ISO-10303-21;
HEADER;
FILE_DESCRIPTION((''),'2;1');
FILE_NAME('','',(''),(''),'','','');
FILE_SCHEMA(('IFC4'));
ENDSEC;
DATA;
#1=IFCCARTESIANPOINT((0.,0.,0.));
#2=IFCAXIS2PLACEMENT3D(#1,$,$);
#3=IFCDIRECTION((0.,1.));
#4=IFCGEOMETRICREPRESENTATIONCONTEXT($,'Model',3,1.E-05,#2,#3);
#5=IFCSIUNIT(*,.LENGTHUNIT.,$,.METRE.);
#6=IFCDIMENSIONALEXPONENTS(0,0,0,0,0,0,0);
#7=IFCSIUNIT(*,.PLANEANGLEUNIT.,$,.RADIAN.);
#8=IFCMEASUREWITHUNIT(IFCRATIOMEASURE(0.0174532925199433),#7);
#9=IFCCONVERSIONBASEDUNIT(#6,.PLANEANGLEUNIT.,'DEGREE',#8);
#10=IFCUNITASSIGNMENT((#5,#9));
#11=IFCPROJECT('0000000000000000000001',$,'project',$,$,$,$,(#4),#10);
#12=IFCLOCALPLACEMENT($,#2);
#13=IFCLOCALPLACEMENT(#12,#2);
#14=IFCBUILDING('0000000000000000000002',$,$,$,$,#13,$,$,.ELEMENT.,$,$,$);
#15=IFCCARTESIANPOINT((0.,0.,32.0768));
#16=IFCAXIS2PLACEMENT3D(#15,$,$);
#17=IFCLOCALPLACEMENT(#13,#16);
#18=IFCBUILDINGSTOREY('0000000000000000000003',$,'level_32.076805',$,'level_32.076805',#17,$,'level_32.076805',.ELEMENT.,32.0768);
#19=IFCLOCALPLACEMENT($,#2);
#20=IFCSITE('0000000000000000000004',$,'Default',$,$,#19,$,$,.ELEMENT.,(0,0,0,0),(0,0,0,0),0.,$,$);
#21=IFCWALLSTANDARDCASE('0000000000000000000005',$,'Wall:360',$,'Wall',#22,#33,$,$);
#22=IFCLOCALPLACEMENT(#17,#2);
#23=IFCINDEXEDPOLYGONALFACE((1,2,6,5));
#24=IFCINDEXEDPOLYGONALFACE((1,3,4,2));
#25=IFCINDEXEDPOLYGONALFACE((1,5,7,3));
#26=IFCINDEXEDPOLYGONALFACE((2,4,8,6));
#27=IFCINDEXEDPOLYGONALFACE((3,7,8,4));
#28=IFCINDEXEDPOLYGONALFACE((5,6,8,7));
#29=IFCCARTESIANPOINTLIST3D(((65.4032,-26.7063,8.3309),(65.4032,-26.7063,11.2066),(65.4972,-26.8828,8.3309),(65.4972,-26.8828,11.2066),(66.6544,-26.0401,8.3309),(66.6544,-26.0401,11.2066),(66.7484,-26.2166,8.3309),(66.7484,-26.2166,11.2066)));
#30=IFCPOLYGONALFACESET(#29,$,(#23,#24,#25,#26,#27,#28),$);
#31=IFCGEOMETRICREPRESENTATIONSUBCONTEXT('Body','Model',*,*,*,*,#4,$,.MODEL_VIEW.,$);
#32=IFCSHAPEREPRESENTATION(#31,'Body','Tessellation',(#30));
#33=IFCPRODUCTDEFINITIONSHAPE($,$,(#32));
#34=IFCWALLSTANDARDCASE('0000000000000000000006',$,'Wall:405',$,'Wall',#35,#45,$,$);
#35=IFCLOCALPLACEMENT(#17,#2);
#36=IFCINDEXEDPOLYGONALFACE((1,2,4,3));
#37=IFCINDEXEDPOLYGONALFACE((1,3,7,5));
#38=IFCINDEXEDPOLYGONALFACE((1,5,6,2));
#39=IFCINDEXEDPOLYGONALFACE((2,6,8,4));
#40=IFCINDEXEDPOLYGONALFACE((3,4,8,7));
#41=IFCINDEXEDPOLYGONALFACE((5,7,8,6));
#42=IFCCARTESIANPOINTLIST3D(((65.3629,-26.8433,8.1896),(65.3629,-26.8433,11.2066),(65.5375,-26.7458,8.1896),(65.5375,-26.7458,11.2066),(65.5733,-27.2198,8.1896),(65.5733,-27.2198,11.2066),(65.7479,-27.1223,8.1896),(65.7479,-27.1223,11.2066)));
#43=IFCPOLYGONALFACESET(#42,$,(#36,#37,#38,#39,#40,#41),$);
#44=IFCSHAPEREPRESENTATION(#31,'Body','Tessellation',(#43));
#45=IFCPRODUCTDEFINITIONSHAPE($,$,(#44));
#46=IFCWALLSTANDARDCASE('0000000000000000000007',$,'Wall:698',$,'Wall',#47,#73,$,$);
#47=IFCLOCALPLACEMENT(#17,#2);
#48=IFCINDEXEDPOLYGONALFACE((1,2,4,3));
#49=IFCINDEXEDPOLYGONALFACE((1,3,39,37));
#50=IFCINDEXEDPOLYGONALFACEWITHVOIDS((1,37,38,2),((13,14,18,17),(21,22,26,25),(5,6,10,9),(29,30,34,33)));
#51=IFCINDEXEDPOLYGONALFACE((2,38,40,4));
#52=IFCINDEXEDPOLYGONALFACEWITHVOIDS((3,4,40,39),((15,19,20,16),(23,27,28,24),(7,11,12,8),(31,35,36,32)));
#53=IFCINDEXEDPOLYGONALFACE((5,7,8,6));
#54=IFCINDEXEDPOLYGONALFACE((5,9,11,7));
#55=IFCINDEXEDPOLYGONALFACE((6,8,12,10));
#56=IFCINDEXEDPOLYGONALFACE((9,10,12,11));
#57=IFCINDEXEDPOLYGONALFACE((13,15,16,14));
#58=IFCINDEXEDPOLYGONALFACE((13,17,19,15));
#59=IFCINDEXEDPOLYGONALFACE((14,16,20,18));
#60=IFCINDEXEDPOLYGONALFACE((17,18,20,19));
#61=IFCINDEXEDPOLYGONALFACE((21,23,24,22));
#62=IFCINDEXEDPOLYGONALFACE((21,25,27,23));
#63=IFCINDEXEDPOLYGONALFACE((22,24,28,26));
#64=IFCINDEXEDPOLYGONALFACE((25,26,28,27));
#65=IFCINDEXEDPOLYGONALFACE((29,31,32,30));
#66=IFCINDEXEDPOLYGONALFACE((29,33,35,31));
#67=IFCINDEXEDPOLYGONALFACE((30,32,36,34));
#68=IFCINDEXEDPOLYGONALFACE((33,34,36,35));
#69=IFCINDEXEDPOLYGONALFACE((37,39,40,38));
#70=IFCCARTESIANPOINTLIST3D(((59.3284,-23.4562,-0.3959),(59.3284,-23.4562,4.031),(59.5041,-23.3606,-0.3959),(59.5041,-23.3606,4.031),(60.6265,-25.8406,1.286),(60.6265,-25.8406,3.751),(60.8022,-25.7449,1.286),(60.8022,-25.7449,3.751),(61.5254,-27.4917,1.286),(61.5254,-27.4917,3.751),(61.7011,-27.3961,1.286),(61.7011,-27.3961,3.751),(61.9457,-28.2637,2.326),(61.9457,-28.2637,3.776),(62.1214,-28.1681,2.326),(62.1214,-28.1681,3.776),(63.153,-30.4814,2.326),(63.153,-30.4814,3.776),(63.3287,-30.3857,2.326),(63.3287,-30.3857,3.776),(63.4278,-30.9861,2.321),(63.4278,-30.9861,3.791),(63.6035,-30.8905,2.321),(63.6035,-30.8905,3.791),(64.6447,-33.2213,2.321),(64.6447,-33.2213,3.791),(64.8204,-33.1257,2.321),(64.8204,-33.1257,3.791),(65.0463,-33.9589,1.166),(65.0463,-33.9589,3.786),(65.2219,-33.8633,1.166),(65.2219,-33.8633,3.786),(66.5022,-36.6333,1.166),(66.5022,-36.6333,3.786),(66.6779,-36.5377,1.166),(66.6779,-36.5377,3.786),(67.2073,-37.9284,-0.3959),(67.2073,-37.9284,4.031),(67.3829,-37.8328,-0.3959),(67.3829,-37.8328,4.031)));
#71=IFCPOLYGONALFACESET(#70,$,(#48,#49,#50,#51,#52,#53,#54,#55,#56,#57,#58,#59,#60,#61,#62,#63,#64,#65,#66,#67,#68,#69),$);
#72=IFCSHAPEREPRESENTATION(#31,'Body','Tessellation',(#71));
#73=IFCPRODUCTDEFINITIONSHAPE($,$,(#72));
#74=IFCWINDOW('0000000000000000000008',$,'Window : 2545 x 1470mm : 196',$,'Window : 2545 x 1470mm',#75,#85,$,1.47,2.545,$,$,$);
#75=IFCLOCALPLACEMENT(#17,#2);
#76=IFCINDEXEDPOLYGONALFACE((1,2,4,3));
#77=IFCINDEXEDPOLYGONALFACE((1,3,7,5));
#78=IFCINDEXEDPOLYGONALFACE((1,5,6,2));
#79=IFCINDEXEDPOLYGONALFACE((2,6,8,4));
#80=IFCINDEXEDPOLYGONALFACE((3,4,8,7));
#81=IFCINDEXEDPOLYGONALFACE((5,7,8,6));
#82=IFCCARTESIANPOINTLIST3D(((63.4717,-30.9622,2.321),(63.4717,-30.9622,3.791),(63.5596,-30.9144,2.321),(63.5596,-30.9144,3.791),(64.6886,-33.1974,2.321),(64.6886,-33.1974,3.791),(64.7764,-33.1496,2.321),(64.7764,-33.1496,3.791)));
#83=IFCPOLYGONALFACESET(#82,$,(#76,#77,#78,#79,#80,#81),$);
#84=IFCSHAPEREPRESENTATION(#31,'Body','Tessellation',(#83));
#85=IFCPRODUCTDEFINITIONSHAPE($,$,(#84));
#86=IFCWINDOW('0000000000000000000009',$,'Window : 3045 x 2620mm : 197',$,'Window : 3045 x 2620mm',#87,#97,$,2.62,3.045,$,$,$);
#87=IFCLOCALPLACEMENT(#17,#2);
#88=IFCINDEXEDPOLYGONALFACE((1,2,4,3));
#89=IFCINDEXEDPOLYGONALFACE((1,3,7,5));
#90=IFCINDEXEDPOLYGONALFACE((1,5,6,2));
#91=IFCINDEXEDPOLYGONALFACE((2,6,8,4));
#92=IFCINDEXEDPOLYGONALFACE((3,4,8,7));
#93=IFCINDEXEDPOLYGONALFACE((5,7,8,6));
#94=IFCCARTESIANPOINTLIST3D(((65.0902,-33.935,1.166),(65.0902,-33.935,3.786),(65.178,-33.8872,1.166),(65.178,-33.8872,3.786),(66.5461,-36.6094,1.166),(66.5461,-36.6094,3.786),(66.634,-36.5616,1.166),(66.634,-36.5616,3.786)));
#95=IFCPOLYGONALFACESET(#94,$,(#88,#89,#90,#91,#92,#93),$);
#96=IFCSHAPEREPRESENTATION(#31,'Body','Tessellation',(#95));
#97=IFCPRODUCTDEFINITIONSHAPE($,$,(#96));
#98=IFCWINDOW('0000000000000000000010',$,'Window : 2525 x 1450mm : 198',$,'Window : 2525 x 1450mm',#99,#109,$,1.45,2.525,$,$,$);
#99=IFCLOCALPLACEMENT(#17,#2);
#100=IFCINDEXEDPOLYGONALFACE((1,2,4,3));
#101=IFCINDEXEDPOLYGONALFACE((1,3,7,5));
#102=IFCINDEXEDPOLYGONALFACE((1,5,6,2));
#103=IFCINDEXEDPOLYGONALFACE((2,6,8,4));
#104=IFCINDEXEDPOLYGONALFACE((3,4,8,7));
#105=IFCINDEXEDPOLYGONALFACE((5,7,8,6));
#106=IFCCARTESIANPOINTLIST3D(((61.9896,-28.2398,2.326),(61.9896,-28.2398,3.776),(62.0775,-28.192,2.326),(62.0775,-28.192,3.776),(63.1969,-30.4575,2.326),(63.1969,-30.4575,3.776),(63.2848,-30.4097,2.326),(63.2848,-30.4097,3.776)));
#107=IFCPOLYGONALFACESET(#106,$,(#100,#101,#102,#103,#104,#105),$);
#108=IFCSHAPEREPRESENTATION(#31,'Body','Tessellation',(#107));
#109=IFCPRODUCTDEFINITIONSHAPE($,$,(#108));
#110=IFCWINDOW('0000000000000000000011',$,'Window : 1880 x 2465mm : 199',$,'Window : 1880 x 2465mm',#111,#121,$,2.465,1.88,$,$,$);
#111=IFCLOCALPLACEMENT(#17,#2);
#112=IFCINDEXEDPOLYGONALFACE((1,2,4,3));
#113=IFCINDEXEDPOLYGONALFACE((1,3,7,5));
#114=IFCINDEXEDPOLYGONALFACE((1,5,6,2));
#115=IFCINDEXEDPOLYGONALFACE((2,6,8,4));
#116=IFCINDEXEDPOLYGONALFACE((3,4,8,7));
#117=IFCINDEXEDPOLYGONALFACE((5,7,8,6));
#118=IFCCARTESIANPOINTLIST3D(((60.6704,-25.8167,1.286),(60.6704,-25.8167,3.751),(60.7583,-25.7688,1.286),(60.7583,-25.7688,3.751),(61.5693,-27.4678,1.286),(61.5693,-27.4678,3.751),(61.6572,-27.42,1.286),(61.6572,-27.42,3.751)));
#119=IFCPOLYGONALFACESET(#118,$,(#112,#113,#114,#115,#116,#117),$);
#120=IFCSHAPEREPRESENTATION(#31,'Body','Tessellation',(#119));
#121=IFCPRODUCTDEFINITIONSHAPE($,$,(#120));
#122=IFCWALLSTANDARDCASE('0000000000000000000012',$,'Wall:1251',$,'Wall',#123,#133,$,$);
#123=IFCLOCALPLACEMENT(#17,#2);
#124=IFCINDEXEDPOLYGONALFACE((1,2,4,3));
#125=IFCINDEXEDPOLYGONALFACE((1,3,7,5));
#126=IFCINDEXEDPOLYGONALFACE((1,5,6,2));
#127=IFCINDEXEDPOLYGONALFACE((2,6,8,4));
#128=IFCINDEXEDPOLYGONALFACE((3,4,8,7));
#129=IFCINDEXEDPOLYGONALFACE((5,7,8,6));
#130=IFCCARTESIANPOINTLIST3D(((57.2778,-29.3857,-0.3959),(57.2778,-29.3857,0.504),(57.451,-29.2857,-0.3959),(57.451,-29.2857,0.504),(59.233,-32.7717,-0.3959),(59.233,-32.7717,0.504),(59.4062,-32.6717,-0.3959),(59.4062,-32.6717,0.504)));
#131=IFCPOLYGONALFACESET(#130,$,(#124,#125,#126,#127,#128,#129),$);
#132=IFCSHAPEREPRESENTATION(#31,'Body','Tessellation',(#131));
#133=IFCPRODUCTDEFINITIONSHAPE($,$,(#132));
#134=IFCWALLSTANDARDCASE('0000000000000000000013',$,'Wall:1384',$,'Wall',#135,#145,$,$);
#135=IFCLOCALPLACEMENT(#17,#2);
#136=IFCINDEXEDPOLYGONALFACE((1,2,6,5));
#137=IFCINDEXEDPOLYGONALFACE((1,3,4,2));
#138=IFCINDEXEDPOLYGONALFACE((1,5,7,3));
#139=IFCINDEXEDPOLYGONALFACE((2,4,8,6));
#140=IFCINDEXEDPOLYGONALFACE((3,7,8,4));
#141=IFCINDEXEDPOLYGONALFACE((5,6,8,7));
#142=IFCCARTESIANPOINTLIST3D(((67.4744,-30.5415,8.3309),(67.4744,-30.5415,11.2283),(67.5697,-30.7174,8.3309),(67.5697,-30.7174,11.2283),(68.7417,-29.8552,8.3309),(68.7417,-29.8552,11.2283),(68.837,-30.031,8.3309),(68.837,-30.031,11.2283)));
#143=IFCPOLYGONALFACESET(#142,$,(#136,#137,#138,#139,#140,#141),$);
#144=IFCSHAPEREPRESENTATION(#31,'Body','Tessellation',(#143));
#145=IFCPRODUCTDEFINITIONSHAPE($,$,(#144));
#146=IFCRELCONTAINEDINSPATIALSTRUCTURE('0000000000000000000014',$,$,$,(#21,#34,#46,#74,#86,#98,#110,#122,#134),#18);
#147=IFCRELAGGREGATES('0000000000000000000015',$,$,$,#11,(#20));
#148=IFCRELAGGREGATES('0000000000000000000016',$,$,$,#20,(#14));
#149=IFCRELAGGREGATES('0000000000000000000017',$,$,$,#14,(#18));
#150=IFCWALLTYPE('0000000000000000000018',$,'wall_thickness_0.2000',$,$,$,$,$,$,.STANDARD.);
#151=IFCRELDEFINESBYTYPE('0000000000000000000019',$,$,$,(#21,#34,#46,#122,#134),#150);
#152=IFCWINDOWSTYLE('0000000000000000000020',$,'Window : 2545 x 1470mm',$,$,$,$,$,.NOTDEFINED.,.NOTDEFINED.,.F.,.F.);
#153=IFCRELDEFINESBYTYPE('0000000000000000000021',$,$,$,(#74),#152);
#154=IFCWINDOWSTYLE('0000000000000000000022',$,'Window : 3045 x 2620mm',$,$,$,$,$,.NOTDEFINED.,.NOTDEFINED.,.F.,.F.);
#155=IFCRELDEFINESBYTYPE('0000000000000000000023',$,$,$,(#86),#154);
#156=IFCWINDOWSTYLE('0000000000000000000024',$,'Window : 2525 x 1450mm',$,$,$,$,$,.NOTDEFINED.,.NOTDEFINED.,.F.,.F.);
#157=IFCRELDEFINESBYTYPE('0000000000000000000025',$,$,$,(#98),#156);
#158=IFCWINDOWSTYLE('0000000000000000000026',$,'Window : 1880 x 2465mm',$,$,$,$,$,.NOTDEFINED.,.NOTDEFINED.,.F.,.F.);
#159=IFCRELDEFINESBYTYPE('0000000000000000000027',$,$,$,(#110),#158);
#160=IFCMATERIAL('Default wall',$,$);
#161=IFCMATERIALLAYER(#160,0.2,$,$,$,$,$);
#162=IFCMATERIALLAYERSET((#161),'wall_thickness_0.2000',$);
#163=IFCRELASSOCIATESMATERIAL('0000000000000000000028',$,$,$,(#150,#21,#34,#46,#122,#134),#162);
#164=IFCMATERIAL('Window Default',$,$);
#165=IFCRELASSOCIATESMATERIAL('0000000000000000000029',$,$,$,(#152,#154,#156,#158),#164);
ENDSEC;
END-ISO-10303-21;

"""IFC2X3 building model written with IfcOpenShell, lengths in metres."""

from ifc_helpers import new_model, entity, si_unit, converted_unit, direction, frame, frame_2d, origin, origin_2d_with_axis, place, context, subcontext, project, spatial, polyline, rectangle, outline, extrude, source, transform, mapped, material, layer, layer_set, layer_usage, type_object, type_shapes, element, fill, save


model = new_model("IFC2X3")

# Units and contexts
model_context = context("Model", 3, precision=1e-05, world=origin(), true_north=direction((0.0, 1.0)))
body_context = subcontext(model_context, "Body", "Model", "MODEL_VIEW")
ifc_project = project(units=[si_unit("LENGTHUNIT", "METRE"), converted_unit("PLANEANGLEUNIT", "DEGREE", entity("IfcRatioMeasure", 0.0174532925199433), si_unit("PLANEANGLEUNIT", "RADIAN"), dimensions=[0, 0, 0, 0, 0, 0, 0])], contexts=[model_context])

# Site, building, storey
site_placement = place(None, origin())
site = spatial("IfcSite", under=ifc_project, at=site_placement, Name="Default", CompositionType="ELEMENT", RefLatitude=(0, 0, 0, 0), RefLongitude=(0, 0, 0, 0), RefElevation=0.0)
placement_1 = place(None, origin())
building_placement = place(placement_1, origin())
building = spatial("IfcBuilding", under=site, at=building_placement, CompositionType="ELEMENT")
storey_placement = place(building_placement, frame((0.0, 0.0, 32.0768)))
storey = spatial("IfcBuildingStorey", under=building, at=storey_placement, Name="level_32.076805", ObjectType="level_32.076805", LongName="level_32.076805", CompositionType="ELEMENT", Elevation=32.0768)

# Walls
ifc_material_1 = material(Name="Default wall")
ifc_layer = layer(ifc_material_1, 0.2)
ifc_layer_set = layer_set([ifc_layer], Name="wall_thickness_0.2000")
ifc_layer_usage = layer_usage(ifc_layer_set, "AXIS2", "POSITIVE", -0.1)
wall_type = type_object("IfcWallType", Name="wall_thickness_0.2000", PredefinedType="STANDARD", material=ifc_layer_set)
placement_2 = place(building_placement, frame((0.0, 0.0, 40.4077)))
wall_1_placement = place(placement_2, frame((66.7014, -26.1283, 0.0), z_axis=(0.0, 0.0, 1.0), x_axis=(-0.88266, -0.470012, 0.0)))
element("IfcWallStandardCase", 1, at=wall_1_placement, inside=storey, type_object=wall_type, material=ifc_layer_usage, Name="Wall:360", ObjectType="Wall", context=body_context, shape_type="SweptSolid", body=[
    extrude(outline(polyline([(1.4175, -0.1), (1.4175, 0.1), (0.0, 0.1), (0.0, -0.1), (1.4175, -0.1)])), origin(), (0.0, 0.0, 1.0), 2.8758),
])
placement_3 = place(building_placement, frame((0.0, 0.0, 40.2664)))
wall_2_placement = place(placement_3, frame((65.4502, -26.7946, 0.0), z_axis=(0.0, 0.0, 1.0), x_axis=(0.487774, -0.87297, 0.0)))
element("IfcWallStandardCase", 2, at=wall_2_placement, inside=storey, type_object=wall_type, material=ifc_layer_usage, Name="Wall:405", ObjectType="Wall", context=body_context, shape_type="SweptSolid", body=[
    extrude(outline(polyline([(0.4313, -0.1), (0.4313, 0.1), (0.0, 0.1), (0.0, -0.1), (0.4313, -0.1)])), origin(), (0.0, 0.0, 1.0), 3.017),
])

# Wall, openings, windows
placement_4 = place(building_placement, frame((0.0, 0.0, 31.6809)))
wall_3_placement = place(placement_4, frame((59.4163, -23.4084, 0.0), z_axis=(0.0, 0.0, 1.0), x_axis=(0.478148, -0.878279, 0.0)))
wall_3 = element("IfcWallStandardCase", 3, at=wall_3_placement, inside=storey, type_object=wall_type, material=ifc_layer_usage, Name="Wall:698", ObjectType="Wall", context=body_context, shape_type="SweptSolid", body=[
    extrude(outline(polyline([(16.4778, -0.1), (16.4778, 0.1), (0.0, 0.1), (0.0, -0.1), (16.4778, -0.1)])), origin(), (0.0, 0.0, 1.0), 4.4269),
])
opening_1_placement = place(wall_3_placement, frame((8.5734, -0.1, 2.7169)))
opening_1 = element("IfcOpeningElement", 4, at=opening_1_placement, cuts=wall_3, ObjectType="Opening", context=body_context, shape_type="SweptSolid", body=[
    extrude(rectangle(XDim=2.545, YDim=1.47, at=frame_2d((0.735, 1.2725), x_axis=(0.0, 1.0))), frame((0.0, 0.0, 0.0), z_axis=(0.0, 1.0, 0.0), x_axis=(0.0, 0.0, 1.0)), (0.0, 0.0, 1.0), 0.2),
])
opening_2_placement = place(wall_3_placement, frame((11.9583, -0.1, 1.5619)))
opening_2 = element("IfcOpeningElement", 5, at=opening_2_placement, cuts=wall_3, ObjectType="Opening", context=body_context, shape_type="SweptSolid", body=[
    extrude(rectangle(XDim=3.045, YDim=2.62, at=frame_2d((1.31, 1.5225), x_axis=(0.0, 1.0))), frame((0.0, 0.0, 0.0), z_axis=(0.0, 1.0, 0.0), x_axis=(0.0, 0.0, 1.0)), (0.0, 0.0, 1.0), 0.2),
])
opening_3_placement = place(wall_3_placement, frame((5.4738, -0.1, 2.7219)))
opening_3 = element("IfcOpeningElement", 6, at=opening_3_placement, cuts=wall_3, ObjectType="Opening", context=body_context, shape_type="SweptSolid", body=[
    extrude(rectangle(XDim=2.525, YDim=1.45, at=frame_2d((0.725, 1.2625), x_axis=(0.0, 1.0))), frame((0.0, 0.0, 0.0), z_axis=(0.0, 1.0, 0.0), x_axis=(0.0, 0.0, 1.0)), (0.0, 0.0, 1.0), 0.2),
])
opening_4_placement = place(wall_3_placement, frame((2.7148, -0.1, 1.6819)))
opening_4 = element("IfcOpeningElement", 7, at=opening_4_placement, cuts=wall_3, ObjectType="Opening", context=body_context, shape_type="SweptSolid", body=[
    extrude(rectangle(XDim=1.88, YDim=2.465, at=frame_2d((1.2325, 0.94), x_axis=(0.0, 1.0))), frame((0.0, 0.0, 0.0), z_axis=(0.0, 1.0, 0.0), x_axis=(0.0, 0.0, 1.0)), (0.0, 0.0, 1.0), 0.2),
])
ifc_material_2 = material(Name="Window Default")
window_style_1 = type_object("IfcWindowStyle", Name="Window : 2545 x 1470mm", ConstructionType="NOTDEFINED", OperationType="NOTDEFINED", ParameterTakesPrecedence=False, Sizeable=False, material=ifc_material_2)
shared_shape_1 = source(origin(), body_context, "Body", "SweptSolid", [
    extrude(rectangle(XDim=0.1, YDim=2.545, at=origin_2d_with_axis()), frame((1.2725, 0.1, 0.0), z_axis=(0.0, 0.0, 1.0), x_axis=(0.0, 1.0, 0.0)), (0.0, 0.0, 1.0), 1.47),
])
type_shapes(window_style_1, [shared_shape_1])
window_1_placement = place(opening_1_placement, origin())
window_1 = element("IfcWindow", 8, at=window_1_placement, inside=storey, type_object=window_style_1, Name="Window : 2545 x 1470mm : 196", ObjectType="Window : 2545 x 1470mm", OverallHeight=1.47, OverallWidth=2.545, context=body_context, shape_type="MappedRepresentation", body=[
    mapped(shared_shape_1, transform((0.0, 0.0, 0.0), scale=1.0)),
])
fill(opening_1, window_1)
window_style_2 = type_object("IfcWindowStyle", Name="Window : 3045 x 2620mm", ConstructionType="NOTDEFINED", OperationType="NOTDEFINED", ParameterTakesPrecedence=False, Sizeable=False, material=ifc_material_2)
shared_shape_2 = source(origin(), body_context, "Body", "SweptSolid", [
    extrude(rectangle(XDim=0.1, YDim=3.045, at=origin_2d_with_axis()), frame((1.5225, 0.1, 0.0), z_axis=(0.0, 0.0, 1.0), x_axis=(0.0, 1.0, 0.0)), (0.0, 0.0, 1.0), 2.62),
])
type_shapes(window_style_2, [shared_shape_2])
window_2_placement = place(opening_2_placement, origin())
window_2 = element("IfcWindow", 9, at=window_2_placement, inside=storey, type_object=window_style_2, Name="Window : 3045 x 2620mm : 197", ObjectType="Window : 3045 x 2620mm", OverallHeight=2.62, OverallWidth=3.045, context=body_context, shape_type="MappedRepresentation", body=[
    mapped(shared_shape_2, transform((0.0, 0.0, 0.0), scale=1.0)),
])
fill(opening_2, window_2)
window_style_3 = type_object("IfcWindowStyle", Name="Window : 2525 x 1450mm", ConstructionType="NOTDEFINED", OperationType="NOTDEFINED", ParameterTakesPrecedence=False, Sizeable=False, material=ifc_material_2)
shared_shape_3 = source(origin(), body_context, "Body", "SweptSolid", [
    extrude(rectangle(XDim=0.1, YDim=2.525, at=origin_2d_with_axis()), frame((1.2625, 0.1, 0.0), z_axis=(0.0, 0.0, 1.0), x_axis=(0.0, 1.0, 0.0)), (0.0, 0.0, 1.0), 1.45),
])
type_shapes(window_style_3, [shared_shape_3])
window_3_placement = place(opening_3_placement, origin())
window_3 = element("IfcWindow", 10, at=window_3_placement, inside=storey, type_object=window_style_3, Name="Window : 2525 x 1450mm : 198", ObjectType="Window : 2525 x 1450mm", OverallHeight=1.45, OverallWidth=2.525, context=body_context, shape_type="MappedRepresentation", body=[
    mapped(shared_shape_3, transform((0.0, 0.0, 0.0), scale=1.0)),
])
fill(opening_3, window_3)
window_style_4 = type_object("IfcWindowStyle", Name="Window : 1880 x 2465mm", ConstructionType="NOTDEFINED", OperationType="NOTDEFINED", ParameterTakesPrecedence=False, Sizeable=False, material=ifc_material_2)
shared_shape_4 = source(origin(), body_context, "Body", "SweptSolid", [
    extrude(rectangle(XDim=0.1, YDim=1.88, at=origin_2d_with_axis()), frame((0.94, 0.1, 0.0), z_axis=(0.0, 0.0, 1.0), x_axis=(0.0, 1.0, 0.0)), (0.0, 0.0, 1.0), 2.465),
])
type_shapes(window_style_4, [shared_shape_4])
window_4_placement = place(opening_4_placement, origin())
window_4 = element("IfcWindow", 11, at=window_4_placement, inside=storey, type_object=window_style_4, Name="Window : 1880 x 2465mm : 199", ObjectType="Window : 1880 x 2465mm", OverallHeight=2.465, OverallWidth=1.88, context=body_context, shape_type="MappedRepresentation", body=[
    mapped(shared_shape_4, transform((0.0, 0.0, 0.0), scale=1.0)),
])
fill(opening_4, window_4)

# Walls
placement_5 = place(building_placement, frame((0.0, 0.0, 31.6809)))
wall_4_placement = place(placement_5, frame((57.3644, -29.3357, 0.0), z_axis=(0.0, 0.0, 1.0), x_axis=(0.500033, -0.866006, 0.0)))
element("IfcWallStandardCase", 12, at=wall_4_placement, inside=storey, type_object=wall_type, material=ifc_layer_usage, Name="Wall:1251", ObjectType="Wall", context=body_context, shape_type="SweptSolid", body=[
    extrude(outline(polyline([(3.91, -0.1), (3.91, 0.1), (0.0, 0.1), (0.0, -0.1), (3.91, -0.1)])), origin(), (0.0, 0.0, 1.0), 0.9),
])
placement_6 = place(building_placement, frame((0.0, 0.0, 40.4077)))
wall_5_placement = place(placement_6, frame((68.7893, -29.9431, 0.0), z_axis=(0.0, 0.0, 1.0), x_axis=(-0.879312, -0.476246, 0.0)))
element("IfcWallStandardCase", 13, at=wall_5_placement, inside=storey, type_object=wall_type, material=ifc_layer_usage, Name="Wall:1384", ObjectType="Wall", context=body_context, shape_type="SweptSolid", body=[
    extrude(outline(polyline([(1.4412, -0.1), (1.4412, 0.1), (0.0, 0.1), (0.0, -0.1), (1.4412, -0.1)])), origin(), (0.0, 0.0, 1.0), 2.8974),
])

save(model, "model.ifc")
